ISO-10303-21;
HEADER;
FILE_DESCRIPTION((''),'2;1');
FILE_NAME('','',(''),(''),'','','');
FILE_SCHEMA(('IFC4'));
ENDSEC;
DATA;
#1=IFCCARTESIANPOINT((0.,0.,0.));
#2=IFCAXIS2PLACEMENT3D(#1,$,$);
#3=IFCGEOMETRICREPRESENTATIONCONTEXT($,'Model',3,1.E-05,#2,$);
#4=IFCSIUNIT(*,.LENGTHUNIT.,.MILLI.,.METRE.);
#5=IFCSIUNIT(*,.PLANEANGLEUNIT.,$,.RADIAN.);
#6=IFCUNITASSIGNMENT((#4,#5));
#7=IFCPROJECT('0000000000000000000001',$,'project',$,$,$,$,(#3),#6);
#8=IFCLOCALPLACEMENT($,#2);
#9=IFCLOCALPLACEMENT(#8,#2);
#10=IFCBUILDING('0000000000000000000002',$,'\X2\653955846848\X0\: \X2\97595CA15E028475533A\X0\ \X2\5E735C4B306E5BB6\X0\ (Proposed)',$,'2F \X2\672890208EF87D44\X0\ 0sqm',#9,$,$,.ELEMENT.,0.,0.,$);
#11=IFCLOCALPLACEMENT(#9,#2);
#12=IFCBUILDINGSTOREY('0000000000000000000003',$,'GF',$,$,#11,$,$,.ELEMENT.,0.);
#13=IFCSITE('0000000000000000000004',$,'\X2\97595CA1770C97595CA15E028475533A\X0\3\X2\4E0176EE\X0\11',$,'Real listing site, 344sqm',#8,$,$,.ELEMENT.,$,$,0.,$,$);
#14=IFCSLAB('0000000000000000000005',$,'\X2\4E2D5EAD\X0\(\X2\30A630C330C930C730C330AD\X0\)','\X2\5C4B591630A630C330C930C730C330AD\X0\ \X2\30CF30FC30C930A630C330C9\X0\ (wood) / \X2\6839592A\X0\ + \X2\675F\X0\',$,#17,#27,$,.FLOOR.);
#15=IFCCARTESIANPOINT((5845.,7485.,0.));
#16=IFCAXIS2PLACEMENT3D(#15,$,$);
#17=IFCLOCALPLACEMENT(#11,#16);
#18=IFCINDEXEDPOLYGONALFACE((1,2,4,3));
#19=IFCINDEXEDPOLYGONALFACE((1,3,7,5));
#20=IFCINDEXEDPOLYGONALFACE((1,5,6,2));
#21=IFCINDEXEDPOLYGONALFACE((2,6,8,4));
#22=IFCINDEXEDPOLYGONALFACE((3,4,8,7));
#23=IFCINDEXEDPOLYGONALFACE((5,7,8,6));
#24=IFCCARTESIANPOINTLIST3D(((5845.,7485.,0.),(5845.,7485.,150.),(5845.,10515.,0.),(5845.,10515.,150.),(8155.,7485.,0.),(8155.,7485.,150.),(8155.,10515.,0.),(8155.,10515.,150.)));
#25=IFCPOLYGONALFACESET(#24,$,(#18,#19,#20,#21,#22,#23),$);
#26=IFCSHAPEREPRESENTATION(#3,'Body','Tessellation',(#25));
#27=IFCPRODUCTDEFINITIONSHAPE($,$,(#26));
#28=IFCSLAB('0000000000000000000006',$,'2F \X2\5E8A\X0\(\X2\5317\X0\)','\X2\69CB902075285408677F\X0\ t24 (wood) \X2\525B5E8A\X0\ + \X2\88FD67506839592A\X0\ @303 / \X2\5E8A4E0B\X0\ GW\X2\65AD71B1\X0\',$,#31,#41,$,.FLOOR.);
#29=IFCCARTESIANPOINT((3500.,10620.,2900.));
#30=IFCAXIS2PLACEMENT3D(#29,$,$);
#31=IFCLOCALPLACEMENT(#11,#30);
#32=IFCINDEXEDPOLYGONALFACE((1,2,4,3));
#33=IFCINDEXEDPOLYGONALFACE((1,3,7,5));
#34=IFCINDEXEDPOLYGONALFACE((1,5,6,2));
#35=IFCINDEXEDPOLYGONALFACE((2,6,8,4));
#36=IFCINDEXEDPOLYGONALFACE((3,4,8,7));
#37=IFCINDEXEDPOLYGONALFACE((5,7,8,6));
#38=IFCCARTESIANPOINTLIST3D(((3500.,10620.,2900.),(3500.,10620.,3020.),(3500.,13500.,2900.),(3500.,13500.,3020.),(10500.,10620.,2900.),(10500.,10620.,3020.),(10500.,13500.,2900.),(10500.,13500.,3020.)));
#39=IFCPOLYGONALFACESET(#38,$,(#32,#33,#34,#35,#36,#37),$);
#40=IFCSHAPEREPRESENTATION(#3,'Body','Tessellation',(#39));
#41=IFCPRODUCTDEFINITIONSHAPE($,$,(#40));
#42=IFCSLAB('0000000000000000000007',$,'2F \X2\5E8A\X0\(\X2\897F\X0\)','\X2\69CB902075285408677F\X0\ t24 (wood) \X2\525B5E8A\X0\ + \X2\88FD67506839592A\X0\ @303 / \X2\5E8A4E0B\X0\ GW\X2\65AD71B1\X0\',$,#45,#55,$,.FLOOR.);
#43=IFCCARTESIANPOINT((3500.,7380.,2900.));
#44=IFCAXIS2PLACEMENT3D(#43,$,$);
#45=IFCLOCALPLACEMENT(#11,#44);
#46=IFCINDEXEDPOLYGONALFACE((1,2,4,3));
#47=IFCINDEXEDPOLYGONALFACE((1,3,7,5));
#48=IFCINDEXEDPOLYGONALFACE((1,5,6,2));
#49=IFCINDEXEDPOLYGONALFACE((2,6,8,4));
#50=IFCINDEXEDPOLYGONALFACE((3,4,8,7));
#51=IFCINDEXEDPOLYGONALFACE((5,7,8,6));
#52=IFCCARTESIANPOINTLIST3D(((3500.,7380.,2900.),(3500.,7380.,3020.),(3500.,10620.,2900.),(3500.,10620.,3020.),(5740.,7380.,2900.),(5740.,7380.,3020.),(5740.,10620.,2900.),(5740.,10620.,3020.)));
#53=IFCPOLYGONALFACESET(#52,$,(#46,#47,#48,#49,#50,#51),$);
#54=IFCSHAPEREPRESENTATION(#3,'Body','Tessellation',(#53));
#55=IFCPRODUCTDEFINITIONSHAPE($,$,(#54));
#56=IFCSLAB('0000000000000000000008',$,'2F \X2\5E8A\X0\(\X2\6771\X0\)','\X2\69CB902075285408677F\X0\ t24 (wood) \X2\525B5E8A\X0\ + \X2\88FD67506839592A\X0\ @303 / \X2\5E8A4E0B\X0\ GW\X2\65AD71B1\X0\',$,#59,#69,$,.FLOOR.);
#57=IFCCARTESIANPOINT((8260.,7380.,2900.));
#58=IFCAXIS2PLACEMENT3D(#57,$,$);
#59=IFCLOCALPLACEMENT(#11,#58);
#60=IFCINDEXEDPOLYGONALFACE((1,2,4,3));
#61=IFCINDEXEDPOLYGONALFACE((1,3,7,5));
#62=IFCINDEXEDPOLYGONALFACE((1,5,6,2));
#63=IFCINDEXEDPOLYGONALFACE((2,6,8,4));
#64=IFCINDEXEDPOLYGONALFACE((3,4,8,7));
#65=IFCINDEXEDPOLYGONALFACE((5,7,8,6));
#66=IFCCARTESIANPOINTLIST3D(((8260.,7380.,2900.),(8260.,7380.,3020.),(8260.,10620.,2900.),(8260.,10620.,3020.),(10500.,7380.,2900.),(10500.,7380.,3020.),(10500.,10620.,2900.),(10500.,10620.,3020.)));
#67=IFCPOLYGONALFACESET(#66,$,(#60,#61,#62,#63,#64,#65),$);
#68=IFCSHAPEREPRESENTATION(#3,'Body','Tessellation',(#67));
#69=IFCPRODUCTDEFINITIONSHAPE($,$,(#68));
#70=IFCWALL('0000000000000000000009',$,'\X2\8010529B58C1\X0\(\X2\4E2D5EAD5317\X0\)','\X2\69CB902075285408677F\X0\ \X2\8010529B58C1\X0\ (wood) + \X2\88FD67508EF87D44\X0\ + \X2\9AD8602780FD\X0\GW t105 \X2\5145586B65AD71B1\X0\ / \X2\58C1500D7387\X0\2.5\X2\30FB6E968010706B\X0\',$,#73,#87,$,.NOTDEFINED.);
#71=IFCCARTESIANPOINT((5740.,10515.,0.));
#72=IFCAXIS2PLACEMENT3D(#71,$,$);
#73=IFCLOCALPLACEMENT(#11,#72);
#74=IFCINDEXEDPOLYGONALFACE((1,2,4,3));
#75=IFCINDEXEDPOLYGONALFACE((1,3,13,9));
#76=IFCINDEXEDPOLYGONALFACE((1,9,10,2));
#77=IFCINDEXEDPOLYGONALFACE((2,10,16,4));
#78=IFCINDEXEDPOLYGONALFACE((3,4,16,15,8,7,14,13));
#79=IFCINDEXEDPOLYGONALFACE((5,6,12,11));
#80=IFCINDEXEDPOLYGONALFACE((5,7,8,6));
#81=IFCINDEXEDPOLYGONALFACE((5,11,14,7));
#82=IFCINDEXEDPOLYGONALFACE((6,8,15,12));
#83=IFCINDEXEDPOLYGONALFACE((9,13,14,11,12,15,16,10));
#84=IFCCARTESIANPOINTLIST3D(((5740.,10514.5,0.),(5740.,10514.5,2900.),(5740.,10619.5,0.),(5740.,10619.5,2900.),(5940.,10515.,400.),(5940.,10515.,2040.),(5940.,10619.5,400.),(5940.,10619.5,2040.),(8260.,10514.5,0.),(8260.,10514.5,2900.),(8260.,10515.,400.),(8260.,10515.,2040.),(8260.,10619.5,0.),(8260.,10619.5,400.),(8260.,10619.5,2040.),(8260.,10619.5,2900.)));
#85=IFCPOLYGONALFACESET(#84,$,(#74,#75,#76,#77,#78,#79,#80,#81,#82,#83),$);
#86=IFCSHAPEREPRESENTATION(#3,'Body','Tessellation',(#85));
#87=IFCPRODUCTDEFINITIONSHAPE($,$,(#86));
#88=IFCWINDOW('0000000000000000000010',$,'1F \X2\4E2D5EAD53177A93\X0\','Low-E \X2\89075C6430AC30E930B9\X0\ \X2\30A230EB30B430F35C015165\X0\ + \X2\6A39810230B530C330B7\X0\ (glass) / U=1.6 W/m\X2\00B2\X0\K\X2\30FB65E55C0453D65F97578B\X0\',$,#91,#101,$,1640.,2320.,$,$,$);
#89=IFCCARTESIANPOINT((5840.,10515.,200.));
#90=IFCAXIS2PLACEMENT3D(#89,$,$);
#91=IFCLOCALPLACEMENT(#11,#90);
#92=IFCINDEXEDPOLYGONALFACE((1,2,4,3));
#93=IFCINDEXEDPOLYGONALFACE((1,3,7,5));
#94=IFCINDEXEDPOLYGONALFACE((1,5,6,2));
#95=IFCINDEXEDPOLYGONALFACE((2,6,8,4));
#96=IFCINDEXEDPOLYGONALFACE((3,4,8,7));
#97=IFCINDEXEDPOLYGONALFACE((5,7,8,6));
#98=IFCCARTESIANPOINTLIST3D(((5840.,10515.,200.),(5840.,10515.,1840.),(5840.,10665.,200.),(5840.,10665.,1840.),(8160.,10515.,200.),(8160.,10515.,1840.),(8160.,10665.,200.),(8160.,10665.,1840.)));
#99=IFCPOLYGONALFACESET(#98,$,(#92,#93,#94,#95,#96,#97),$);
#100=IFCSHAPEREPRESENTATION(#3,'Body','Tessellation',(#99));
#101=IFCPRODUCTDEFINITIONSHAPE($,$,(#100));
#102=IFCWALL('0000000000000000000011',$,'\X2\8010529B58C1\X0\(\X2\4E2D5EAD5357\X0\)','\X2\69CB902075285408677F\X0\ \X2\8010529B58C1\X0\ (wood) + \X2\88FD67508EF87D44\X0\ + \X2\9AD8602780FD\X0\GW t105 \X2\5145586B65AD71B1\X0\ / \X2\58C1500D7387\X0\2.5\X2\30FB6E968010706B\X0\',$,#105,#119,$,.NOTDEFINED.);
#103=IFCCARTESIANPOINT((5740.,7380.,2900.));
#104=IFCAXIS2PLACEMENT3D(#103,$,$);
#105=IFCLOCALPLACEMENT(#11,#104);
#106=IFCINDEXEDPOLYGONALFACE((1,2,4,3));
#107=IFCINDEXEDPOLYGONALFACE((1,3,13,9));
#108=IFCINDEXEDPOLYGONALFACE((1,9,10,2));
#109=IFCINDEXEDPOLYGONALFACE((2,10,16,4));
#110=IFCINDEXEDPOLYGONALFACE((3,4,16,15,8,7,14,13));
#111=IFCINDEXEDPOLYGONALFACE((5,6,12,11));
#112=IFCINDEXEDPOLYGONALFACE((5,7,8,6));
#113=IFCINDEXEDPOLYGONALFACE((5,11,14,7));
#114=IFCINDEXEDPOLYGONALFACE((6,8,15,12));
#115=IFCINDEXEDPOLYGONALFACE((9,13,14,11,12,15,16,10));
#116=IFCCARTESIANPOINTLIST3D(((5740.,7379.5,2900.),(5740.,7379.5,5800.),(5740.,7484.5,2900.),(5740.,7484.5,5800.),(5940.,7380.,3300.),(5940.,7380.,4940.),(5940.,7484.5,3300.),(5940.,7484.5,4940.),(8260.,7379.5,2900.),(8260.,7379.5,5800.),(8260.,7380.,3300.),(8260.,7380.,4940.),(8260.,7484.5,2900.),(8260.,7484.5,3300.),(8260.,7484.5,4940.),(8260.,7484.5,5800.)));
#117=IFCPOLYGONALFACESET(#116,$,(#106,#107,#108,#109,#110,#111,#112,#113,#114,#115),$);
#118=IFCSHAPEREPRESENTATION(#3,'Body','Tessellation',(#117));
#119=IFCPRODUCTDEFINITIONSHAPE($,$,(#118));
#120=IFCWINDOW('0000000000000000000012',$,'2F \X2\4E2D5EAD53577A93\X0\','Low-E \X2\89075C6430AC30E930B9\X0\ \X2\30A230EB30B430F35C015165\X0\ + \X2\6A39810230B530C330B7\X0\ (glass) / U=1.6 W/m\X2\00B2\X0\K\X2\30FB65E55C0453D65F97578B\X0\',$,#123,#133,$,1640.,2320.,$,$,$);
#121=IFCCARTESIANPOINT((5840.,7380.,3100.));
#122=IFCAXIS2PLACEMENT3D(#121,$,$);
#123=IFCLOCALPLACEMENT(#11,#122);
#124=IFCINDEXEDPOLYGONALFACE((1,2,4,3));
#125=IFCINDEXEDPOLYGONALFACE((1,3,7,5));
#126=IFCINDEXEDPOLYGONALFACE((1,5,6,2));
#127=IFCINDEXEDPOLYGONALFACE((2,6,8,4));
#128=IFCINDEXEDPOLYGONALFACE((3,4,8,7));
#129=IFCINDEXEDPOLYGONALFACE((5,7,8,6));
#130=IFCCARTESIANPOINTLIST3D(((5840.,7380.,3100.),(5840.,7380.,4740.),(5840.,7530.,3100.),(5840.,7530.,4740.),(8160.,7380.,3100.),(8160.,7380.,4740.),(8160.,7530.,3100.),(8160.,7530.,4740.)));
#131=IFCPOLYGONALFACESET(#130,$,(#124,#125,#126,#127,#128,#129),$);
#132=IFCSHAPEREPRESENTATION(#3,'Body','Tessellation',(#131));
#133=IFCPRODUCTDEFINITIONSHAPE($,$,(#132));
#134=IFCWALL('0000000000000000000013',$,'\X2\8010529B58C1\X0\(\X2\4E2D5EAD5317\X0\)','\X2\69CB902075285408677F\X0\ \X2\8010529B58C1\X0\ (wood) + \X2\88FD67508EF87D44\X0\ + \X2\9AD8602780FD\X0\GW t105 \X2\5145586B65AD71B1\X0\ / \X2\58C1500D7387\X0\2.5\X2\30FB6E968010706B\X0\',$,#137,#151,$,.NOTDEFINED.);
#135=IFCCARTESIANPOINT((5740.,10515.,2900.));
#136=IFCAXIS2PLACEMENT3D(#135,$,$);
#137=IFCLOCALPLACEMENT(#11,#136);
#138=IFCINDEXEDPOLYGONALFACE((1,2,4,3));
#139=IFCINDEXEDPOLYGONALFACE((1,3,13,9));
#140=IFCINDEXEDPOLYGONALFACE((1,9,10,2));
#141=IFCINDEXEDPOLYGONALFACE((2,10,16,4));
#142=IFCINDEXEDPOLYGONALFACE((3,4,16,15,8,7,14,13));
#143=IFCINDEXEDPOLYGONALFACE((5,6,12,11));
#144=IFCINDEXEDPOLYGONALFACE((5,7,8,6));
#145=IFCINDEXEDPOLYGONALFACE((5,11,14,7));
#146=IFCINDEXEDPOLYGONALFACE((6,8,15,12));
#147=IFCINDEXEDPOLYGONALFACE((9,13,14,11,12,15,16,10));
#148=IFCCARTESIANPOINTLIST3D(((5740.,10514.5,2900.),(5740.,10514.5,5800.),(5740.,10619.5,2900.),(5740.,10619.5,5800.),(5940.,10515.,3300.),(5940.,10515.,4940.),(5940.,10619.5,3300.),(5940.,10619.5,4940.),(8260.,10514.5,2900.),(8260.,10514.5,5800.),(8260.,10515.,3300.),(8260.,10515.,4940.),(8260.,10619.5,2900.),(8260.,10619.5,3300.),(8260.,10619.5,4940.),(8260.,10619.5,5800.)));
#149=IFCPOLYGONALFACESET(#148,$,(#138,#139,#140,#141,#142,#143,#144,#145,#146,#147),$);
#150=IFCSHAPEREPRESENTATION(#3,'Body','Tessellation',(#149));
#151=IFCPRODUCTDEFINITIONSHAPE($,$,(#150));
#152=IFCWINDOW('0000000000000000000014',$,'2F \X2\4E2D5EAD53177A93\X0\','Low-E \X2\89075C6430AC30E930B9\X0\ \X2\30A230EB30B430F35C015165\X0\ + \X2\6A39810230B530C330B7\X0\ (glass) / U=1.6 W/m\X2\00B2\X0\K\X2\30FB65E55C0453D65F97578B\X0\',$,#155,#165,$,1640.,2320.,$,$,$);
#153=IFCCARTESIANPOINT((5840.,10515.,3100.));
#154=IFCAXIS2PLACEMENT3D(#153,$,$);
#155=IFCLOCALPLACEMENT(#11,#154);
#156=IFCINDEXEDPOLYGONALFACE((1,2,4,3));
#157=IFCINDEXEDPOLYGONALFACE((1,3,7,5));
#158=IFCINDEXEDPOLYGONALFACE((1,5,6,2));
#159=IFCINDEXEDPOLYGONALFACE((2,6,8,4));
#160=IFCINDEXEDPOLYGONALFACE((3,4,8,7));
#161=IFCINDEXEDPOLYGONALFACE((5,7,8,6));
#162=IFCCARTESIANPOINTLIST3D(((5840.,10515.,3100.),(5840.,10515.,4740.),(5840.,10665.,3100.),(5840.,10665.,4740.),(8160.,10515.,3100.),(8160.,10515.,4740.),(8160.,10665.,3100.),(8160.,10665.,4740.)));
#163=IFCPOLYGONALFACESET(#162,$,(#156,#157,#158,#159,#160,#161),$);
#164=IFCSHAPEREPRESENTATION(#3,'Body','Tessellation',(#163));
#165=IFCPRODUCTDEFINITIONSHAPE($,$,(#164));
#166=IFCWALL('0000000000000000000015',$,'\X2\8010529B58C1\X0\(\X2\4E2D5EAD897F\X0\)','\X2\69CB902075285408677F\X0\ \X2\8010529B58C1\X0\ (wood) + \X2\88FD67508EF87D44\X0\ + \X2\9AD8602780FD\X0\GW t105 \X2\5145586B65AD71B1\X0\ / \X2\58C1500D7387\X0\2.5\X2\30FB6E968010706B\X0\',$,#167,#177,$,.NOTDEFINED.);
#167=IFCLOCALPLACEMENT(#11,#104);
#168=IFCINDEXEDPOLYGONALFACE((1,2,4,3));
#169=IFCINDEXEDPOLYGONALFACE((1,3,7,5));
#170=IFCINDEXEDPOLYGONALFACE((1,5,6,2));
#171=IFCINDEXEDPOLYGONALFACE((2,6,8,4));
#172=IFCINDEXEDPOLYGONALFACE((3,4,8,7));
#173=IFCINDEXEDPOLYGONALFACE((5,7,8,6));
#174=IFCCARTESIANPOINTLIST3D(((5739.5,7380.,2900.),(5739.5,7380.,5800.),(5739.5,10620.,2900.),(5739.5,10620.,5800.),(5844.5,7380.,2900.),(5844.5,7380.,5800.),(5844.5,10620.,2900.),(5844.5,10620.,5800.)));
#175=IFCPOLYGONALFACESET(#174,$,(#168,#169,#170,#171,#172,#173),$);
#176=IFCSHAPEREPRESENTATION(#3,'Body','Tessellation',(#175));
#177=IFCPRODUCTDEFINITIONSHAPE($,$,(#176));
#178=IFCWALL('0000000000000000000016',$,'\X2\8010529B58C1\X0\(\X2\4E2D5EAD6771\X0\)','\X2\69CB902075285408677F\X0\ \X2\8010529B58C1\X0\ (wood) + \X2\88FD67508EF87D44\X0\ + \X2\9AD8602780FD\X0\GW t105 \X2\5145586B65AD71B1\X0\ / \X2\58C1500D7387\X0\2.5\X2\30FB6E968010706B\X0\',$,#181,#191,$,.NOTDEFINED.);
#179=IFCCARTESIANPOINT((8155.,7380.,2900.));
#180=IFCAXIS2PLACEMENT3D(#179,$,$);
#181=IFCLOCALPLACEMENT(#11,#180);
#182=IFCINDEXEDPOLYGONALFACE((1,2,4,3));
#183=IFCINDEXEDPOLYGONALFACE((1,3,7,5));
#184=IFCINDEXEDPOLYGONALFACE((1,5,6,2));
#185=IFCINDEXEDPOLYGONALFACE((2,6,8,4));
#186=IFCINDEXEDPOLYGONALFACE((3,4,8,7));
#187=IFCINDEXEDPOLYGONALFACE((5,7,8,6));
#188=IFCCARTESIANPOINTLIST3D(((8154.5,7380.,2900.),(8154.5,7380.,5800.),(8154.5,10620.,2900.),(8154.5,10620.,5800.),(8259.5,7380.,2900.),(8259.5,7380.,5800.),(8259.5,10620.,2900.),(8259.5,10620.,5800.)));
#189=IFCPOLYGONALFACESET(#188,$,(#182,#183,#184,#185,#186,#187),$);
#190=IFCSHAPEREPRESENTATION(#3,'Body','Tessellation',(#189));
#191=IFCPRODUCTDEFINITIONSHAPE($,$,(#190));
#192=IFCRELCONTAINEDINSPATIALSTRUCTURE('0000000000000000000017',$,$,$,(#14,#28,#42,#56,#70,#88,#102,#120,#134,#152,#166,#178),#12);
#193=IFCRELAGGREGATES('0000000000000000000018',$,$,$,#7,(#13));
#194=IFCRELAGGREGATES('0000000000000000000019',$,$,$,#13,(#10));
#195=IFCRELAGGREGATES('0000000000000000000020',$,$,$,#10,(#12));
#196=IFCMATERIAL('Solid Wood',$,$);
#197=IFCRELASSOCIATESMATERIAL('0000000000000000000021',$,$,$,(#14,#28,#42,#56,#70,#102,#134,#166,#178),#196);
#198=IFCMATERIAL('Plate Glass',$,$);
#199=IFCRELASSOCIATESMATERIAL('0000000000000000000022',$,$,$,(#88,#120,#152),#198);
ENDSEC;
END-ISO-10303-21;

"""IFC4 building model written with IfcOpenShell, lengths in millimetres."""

from ifc_helpers import new_model, si_unit, frame, frame_2d, origin, place, context, project, spatial, rectangle, extrude, material, element, fill, save


model = new_model("IFC4")

# Units and contexts
model_context = context("Model", 3, precision=1e-05, world=origin())
ifc_project = project(units=[si_unit("LENGTHUNIT", "METRE", prefix="MILLI"), si_unit("PLANEANGLEUNIT", "RADIAN")], contexts=[model_context])

# Site, building, storey
site_placement = place(None, origin())
site = spatial("IfcSite", under=ifc_project, at=site_placement, Name="静岡県静岡市葵区3丁目11", ObjectType="Real listing site, 344sqm", CompositionType="ELEMENT", RefElevation=0.0)
building_placement = place(site_placement, origin())
building = spatial("IfcBuilding", under=site, at=building_placement, Name="改善案: 静岡市葵区 平屋の家 (Proposed)", ObjectType="2F 木造軸組 0sqm", CompositionType="ELEMENT", ElevationOfRefHeight=0.0, ElevationOfTerrain=0.0)
storey_placement = place(building_placement, origin())
storey = spatial("IfcBuildingStorey", under=building, at=storey_placement, Name="GF", CompositionType="ELEMENT", Elevation=0.0)

# Slabs
ifc_material_1 = material(Name="Solid Wood")
slab_1_placement = place(storey_placement, frame((5845.0, 7485.0, 0.0)))
element("IfcSlab", 1, at=slab_1_placement, inside=storey, material=ifc_material_1, Name="中庭(ウッドデッキ)", Description="屋外ウッドデッキ ハードウッド (wood) / 根太 + 束", PredefinedType="FLOOR", context=model_context, shape_type="SweptSolid", body=[
    extrude(rectangle(XDim=2310.0, YDim=3030.0, at=frame_2d((1155.0, 1515.0))), frame((5845.0, 7485.0, 0.0)), (0.0, 0.0, 1.0), 150.0),
])
slab_2_placement = place(storey_placement, frame((3500.0, 10620.0, 2900.0)))
element("IfcSlab", 2, at=slab_2_placement, inside=storey, material=ifc_material_1, Name="2F 床(北)", Description="構造用合板 t24 (wood) 剛床 + 製材根太 @303 / 床下 GW断熱", PredefinedType="FLOOR", context=model_context, shape_type="SweptSolid", body=[
    extrude(rectangle(XDim=7000.0, YDim=2880.0, at=frame_2d((3500.0, 1440.0))), frame((3500.0, 10620.0, 2900.0)), (0.0, 0.0, 1.0), 120.0),
])
slab_3_placement = place(storey_placement, frame((3500.0, 7380.0, 2900.0)))
element("IfcSlab", 3, at=slab_3_placement, inside=storey, material=ifc_material_1, Name="2F 床(西)", Description="構造用合板 t24 (wood) 剛床 + 製材根太 @303 / 床下 GW断熱", PredefinedType="FLOOR", context=model_context, shape_type="SweptSolid", body=[
    extrude(rectangle(XDim=2240.0, YDim=3240.0, at=frame_2d((1120.0, 1620.0))), frame((3500.0, 7380.0, 2900.0)), (0.0, 0.0, 1.0), 120.0),
])
slab_4_placement = place(storey_placement, frame((8260.0, 7380.0, 2900.0)))
element("IfcSlab", 4, at=slab_4_placement, inside=storey, material=ifc_material_1, Name="2F 床(東)", Description="構造用合板 t24 (wood) 剛床 + 製材根太 @303 / 床下 GW断熱", PredefinedType="FLOOR", context=model_context, shape_type="SweptSolid", body=[
    extrude(rectangle(XDim=2240.0, YDim=3240.0, at=frame_2d((1120.0, 1620.0))), frame((8260.0, 7380.0, 2900.0)), (0.0, 0.0, 1.0), 120.0),
])

# Wall, opening, window
wall_1_placement = place(storey_placement, frame((5740.0, 10515.0, 0.0)))
wall_1 = element("IfcWall", 5, at=wall_1_placement, inside=storey, material=ifc_material_1, Name="耐力壁(中庭北)", Description="構造用合板 耐力壁 (wood) + 製材軸組 + 高性能GW t105 充填断熱 / 壁倍率2.5・準耐火", PredefinedType="NOTDEFINED", context=model_context, shape_type="SweptSolid", body=[
    extrude(rectangle(XDim=2520.0, YDim=105.0, at=frame_2d((1260.0, 52.0))), frame((5740.0, 10515.0, 0.0)), (0.0, 0.0, 1.0), 2900.0),
])
opening_1_placement = place(storey_placement, frame((5840.0, 10515.0, 200.0)))
opening_1 = element("IfcOpeningElement", 6, at=opening_1_placement, cuts=wall_1, PredefinedType="NOTDEFINED", context=model_context, shape_type="SweptSolid", body=[
    extrude(rectangle(XDim=2320.0, YDim=150.0, at=frame_2d((1160.0, 75.0))), frame((5840.0, 10515.0, 200.0)), (0.0, 0.0, 1.0), 1640.0),
])
ifc_material_2 = material(Name="Plate Glass")
window_1_placement = place(storey_placement, frame((5840.0, 10515.0, 200.0)))
window_1 = element("IfcWindow", 7, at=window_1_placement, inside=storey, material=ifc_material_2, Name="1F 中庭北窓", Description="Low-E 複層ガラス アルゴン封入 + 樹脂サッシ (glass) / U=1.6 W/m²K・日射取得型", OverallHeight=1640.0, OverallWidth=2320.0, context=model_context, shape_type="SweptSolid", body=[
    extrude(rectangle(XDim=2320.0, YDim=150.0, at=frame_2d((1160.0, 75.0))), frame((5840.0, 10515.0, 200.0)), (0.0, 0.0, 1.0), 1640.0),
])
fill(opening_1, window_1)

# Walls, openings, windows
wall_2_placement = place(storey_placement, frame((5740.0, 7380.0, 2900.0)))
wall_2 = element("IfcWall", 8, at=wall_2_placement, inside=storey, material=ifc_material_1, Name="耐力壁(中庭南)", Description="構造用合板 耐力壁 (wood) + 製材軸組 + 高性能GW t105 充填断熱 / 壁倍率2.5・準耐火", PredefinedType="NOTDEFINED", context=model_context, shape_type="SweptSolid", body=[
    extrude(rectangle(XDim=2520.0, YDim=105.0, at=frame_2d((1260.0, 52.0))), frame((5740.0, 7380.0, 2900.0)), (0.0, 0.0, 1.0), 2900.0),
])
opening_2_placement = place(storey_placement, frame((5840.0, 7380.0, 3100.0)))
opening_2 = element("IfcOpeningElement", 9, at=opening_2_placement, cuts=wall_2, PredefinedType="NOTDEFINED", context=model_context, shape_type="SweptSolid", body=[
    extrude(rectangle(XDim=2320.0, YDim=150.0, at=frame_2d((1160.0, 75.0))), frame((5840.0, 7380.0, 3100.0)), (0.0, 0.0, 1.0), 1640.0),
])
window_2_placement = place(storey_placement, frame((5840.0, 7380.0, 3100.0)))
window_2 = element("IfcWindow", 10, at=window_2_placement, inside=storey, material=ifc_material_2, Name="2F 中庭南窓", Description="Low-E 複層ガラス アルゴン封入 + 樹脂サッシ (glass) / U=1.6 W/m²K・日射取得型", OverallHeight=1640.0, OverallWidth=2320.0, context=model_context, shape_type="SweptSolid", body=[
    extrude(rectangle(XDim=2320.0, YDim=150.0, at=frame_2d((1160.0, 75.0))), frame((5840.0, 7380.0, 3100.0)), (0.0, 0.0, 1.0), 1640.0),
])
fill(opening_2, window_2)
wall_3_placement = place(storey_placement, frame((5740.0, 10515.0, 2900.0)))
wall_3 = element("IfcWall", 11, at=wall_3_placement, inside=storey, material=ifc_material_1, Name="耐力壁(中庭北)", Description="構造用合板 耐力壁 (wood) + 製材軸組 + 高性能GW t105 充填断熱 / 壁倍率2.5・準耐火", PredefinedType="NOTDEFINED", context=model_context, shape_type="SweptSolid", body=[
    extrude(rectangle(XDim=2520.0, YDim=105.0, at=frame_2d((1260.0, 52.0))), frame((5740.0, 10515.0, 2900.0)), (0.0, 0.0, 1.0), 2900.0),
])
opening_3_placement = place(storey_placement, frame((5840.0, 10515.0, 3100.0)))
opening_3 = element("IfcOpeningElement", 12, at=opening_3_placement, cuts=wall_3, PredefinedType="NOTDEFINED", context=model_context, shape_type="SweptSolid", body=[
    extrude(rectangle(XDim=2320.0, YDim=150.0, at=frame_2d((1160.0, 75.0))), frame((5840.0, 10515.0, 3100.0)), (0.0, 0.0, 1.0), 1640.0),
])
window_3_placement = place(storey_placement, frame((5840.0, 10515.0, 3100.0)))
window_3 = element("IfcWindow", 13, at=window_3_placement, inside=storey, material=ifc_material_2, Name="2F 中庭北窓", Description="Low-E 複層ガラス アルゴン封入 + 樹脂サッシ (glass) / U=1.6 W/m²K・日射取得型", OverallHeight=1640.0, OverallWidth=2320.0, context=model_context, shape_type="SweptSolid", body=[
    extrude(rectangle(XDim=2320.0, YDim=150.0, at=frame_2d((1160.0, 75.0))), frame((5840.0, 10515.0, 3100.0)), (0.0, 0.0, 1.0), 1640.0),
])
fill(opening_3, window_3)

# Walls
wall_4_placement = place(storey_placement, frame((5740.0, 7380.0, 2900.0)))
element("IfcWall", 14, at=wall_4_placement, inside=storey, material=ifc_material_1, Name="耐力壁(中庭西)", Description="構造用合板 耐力壁 (wood) + 製材軸組 + 高性能GW t105 充填断熱 / 壁倍率2.5・準耐火", PredefinedType="NOTDEFINED", context=model_context, shape_type="SweptSolid", body=[
    extrude(rectangle(XDim=105.0, YDim=3240.0, at=frame_2d((52.0, 1620.0))), frame((5740.0, 7380.0, 2900.0)), (0.0, 0.0, 1.0), 2900.0),
])
wall_5_placement = place(storey_placement, frame((8155.0, 7380.0, 2900.0)))
element("IfcWall", 15, at=wall_5_placement, inside=storey, material=ifc_material_1, Name="耐力壁(中庭東)", Description="構造用合板 耐力壁 (wood) + 製材軸組 + 高性能GW t105 充填断熱 / 壁倍率2.5・準耐火", PredefinedType="NOTDEFINED", context=model_context, shape_type="SweptSolid", body=[
    extrude(rectangle(XDim=105.0, YDim=3240.0, at=frame_2d((52.0, 1620.0))), frame((8155.0, 7380.0, 2900.0)), (0.0, 0.0, 1.0), 2900.0),
])

save(model, "model.ifc")
